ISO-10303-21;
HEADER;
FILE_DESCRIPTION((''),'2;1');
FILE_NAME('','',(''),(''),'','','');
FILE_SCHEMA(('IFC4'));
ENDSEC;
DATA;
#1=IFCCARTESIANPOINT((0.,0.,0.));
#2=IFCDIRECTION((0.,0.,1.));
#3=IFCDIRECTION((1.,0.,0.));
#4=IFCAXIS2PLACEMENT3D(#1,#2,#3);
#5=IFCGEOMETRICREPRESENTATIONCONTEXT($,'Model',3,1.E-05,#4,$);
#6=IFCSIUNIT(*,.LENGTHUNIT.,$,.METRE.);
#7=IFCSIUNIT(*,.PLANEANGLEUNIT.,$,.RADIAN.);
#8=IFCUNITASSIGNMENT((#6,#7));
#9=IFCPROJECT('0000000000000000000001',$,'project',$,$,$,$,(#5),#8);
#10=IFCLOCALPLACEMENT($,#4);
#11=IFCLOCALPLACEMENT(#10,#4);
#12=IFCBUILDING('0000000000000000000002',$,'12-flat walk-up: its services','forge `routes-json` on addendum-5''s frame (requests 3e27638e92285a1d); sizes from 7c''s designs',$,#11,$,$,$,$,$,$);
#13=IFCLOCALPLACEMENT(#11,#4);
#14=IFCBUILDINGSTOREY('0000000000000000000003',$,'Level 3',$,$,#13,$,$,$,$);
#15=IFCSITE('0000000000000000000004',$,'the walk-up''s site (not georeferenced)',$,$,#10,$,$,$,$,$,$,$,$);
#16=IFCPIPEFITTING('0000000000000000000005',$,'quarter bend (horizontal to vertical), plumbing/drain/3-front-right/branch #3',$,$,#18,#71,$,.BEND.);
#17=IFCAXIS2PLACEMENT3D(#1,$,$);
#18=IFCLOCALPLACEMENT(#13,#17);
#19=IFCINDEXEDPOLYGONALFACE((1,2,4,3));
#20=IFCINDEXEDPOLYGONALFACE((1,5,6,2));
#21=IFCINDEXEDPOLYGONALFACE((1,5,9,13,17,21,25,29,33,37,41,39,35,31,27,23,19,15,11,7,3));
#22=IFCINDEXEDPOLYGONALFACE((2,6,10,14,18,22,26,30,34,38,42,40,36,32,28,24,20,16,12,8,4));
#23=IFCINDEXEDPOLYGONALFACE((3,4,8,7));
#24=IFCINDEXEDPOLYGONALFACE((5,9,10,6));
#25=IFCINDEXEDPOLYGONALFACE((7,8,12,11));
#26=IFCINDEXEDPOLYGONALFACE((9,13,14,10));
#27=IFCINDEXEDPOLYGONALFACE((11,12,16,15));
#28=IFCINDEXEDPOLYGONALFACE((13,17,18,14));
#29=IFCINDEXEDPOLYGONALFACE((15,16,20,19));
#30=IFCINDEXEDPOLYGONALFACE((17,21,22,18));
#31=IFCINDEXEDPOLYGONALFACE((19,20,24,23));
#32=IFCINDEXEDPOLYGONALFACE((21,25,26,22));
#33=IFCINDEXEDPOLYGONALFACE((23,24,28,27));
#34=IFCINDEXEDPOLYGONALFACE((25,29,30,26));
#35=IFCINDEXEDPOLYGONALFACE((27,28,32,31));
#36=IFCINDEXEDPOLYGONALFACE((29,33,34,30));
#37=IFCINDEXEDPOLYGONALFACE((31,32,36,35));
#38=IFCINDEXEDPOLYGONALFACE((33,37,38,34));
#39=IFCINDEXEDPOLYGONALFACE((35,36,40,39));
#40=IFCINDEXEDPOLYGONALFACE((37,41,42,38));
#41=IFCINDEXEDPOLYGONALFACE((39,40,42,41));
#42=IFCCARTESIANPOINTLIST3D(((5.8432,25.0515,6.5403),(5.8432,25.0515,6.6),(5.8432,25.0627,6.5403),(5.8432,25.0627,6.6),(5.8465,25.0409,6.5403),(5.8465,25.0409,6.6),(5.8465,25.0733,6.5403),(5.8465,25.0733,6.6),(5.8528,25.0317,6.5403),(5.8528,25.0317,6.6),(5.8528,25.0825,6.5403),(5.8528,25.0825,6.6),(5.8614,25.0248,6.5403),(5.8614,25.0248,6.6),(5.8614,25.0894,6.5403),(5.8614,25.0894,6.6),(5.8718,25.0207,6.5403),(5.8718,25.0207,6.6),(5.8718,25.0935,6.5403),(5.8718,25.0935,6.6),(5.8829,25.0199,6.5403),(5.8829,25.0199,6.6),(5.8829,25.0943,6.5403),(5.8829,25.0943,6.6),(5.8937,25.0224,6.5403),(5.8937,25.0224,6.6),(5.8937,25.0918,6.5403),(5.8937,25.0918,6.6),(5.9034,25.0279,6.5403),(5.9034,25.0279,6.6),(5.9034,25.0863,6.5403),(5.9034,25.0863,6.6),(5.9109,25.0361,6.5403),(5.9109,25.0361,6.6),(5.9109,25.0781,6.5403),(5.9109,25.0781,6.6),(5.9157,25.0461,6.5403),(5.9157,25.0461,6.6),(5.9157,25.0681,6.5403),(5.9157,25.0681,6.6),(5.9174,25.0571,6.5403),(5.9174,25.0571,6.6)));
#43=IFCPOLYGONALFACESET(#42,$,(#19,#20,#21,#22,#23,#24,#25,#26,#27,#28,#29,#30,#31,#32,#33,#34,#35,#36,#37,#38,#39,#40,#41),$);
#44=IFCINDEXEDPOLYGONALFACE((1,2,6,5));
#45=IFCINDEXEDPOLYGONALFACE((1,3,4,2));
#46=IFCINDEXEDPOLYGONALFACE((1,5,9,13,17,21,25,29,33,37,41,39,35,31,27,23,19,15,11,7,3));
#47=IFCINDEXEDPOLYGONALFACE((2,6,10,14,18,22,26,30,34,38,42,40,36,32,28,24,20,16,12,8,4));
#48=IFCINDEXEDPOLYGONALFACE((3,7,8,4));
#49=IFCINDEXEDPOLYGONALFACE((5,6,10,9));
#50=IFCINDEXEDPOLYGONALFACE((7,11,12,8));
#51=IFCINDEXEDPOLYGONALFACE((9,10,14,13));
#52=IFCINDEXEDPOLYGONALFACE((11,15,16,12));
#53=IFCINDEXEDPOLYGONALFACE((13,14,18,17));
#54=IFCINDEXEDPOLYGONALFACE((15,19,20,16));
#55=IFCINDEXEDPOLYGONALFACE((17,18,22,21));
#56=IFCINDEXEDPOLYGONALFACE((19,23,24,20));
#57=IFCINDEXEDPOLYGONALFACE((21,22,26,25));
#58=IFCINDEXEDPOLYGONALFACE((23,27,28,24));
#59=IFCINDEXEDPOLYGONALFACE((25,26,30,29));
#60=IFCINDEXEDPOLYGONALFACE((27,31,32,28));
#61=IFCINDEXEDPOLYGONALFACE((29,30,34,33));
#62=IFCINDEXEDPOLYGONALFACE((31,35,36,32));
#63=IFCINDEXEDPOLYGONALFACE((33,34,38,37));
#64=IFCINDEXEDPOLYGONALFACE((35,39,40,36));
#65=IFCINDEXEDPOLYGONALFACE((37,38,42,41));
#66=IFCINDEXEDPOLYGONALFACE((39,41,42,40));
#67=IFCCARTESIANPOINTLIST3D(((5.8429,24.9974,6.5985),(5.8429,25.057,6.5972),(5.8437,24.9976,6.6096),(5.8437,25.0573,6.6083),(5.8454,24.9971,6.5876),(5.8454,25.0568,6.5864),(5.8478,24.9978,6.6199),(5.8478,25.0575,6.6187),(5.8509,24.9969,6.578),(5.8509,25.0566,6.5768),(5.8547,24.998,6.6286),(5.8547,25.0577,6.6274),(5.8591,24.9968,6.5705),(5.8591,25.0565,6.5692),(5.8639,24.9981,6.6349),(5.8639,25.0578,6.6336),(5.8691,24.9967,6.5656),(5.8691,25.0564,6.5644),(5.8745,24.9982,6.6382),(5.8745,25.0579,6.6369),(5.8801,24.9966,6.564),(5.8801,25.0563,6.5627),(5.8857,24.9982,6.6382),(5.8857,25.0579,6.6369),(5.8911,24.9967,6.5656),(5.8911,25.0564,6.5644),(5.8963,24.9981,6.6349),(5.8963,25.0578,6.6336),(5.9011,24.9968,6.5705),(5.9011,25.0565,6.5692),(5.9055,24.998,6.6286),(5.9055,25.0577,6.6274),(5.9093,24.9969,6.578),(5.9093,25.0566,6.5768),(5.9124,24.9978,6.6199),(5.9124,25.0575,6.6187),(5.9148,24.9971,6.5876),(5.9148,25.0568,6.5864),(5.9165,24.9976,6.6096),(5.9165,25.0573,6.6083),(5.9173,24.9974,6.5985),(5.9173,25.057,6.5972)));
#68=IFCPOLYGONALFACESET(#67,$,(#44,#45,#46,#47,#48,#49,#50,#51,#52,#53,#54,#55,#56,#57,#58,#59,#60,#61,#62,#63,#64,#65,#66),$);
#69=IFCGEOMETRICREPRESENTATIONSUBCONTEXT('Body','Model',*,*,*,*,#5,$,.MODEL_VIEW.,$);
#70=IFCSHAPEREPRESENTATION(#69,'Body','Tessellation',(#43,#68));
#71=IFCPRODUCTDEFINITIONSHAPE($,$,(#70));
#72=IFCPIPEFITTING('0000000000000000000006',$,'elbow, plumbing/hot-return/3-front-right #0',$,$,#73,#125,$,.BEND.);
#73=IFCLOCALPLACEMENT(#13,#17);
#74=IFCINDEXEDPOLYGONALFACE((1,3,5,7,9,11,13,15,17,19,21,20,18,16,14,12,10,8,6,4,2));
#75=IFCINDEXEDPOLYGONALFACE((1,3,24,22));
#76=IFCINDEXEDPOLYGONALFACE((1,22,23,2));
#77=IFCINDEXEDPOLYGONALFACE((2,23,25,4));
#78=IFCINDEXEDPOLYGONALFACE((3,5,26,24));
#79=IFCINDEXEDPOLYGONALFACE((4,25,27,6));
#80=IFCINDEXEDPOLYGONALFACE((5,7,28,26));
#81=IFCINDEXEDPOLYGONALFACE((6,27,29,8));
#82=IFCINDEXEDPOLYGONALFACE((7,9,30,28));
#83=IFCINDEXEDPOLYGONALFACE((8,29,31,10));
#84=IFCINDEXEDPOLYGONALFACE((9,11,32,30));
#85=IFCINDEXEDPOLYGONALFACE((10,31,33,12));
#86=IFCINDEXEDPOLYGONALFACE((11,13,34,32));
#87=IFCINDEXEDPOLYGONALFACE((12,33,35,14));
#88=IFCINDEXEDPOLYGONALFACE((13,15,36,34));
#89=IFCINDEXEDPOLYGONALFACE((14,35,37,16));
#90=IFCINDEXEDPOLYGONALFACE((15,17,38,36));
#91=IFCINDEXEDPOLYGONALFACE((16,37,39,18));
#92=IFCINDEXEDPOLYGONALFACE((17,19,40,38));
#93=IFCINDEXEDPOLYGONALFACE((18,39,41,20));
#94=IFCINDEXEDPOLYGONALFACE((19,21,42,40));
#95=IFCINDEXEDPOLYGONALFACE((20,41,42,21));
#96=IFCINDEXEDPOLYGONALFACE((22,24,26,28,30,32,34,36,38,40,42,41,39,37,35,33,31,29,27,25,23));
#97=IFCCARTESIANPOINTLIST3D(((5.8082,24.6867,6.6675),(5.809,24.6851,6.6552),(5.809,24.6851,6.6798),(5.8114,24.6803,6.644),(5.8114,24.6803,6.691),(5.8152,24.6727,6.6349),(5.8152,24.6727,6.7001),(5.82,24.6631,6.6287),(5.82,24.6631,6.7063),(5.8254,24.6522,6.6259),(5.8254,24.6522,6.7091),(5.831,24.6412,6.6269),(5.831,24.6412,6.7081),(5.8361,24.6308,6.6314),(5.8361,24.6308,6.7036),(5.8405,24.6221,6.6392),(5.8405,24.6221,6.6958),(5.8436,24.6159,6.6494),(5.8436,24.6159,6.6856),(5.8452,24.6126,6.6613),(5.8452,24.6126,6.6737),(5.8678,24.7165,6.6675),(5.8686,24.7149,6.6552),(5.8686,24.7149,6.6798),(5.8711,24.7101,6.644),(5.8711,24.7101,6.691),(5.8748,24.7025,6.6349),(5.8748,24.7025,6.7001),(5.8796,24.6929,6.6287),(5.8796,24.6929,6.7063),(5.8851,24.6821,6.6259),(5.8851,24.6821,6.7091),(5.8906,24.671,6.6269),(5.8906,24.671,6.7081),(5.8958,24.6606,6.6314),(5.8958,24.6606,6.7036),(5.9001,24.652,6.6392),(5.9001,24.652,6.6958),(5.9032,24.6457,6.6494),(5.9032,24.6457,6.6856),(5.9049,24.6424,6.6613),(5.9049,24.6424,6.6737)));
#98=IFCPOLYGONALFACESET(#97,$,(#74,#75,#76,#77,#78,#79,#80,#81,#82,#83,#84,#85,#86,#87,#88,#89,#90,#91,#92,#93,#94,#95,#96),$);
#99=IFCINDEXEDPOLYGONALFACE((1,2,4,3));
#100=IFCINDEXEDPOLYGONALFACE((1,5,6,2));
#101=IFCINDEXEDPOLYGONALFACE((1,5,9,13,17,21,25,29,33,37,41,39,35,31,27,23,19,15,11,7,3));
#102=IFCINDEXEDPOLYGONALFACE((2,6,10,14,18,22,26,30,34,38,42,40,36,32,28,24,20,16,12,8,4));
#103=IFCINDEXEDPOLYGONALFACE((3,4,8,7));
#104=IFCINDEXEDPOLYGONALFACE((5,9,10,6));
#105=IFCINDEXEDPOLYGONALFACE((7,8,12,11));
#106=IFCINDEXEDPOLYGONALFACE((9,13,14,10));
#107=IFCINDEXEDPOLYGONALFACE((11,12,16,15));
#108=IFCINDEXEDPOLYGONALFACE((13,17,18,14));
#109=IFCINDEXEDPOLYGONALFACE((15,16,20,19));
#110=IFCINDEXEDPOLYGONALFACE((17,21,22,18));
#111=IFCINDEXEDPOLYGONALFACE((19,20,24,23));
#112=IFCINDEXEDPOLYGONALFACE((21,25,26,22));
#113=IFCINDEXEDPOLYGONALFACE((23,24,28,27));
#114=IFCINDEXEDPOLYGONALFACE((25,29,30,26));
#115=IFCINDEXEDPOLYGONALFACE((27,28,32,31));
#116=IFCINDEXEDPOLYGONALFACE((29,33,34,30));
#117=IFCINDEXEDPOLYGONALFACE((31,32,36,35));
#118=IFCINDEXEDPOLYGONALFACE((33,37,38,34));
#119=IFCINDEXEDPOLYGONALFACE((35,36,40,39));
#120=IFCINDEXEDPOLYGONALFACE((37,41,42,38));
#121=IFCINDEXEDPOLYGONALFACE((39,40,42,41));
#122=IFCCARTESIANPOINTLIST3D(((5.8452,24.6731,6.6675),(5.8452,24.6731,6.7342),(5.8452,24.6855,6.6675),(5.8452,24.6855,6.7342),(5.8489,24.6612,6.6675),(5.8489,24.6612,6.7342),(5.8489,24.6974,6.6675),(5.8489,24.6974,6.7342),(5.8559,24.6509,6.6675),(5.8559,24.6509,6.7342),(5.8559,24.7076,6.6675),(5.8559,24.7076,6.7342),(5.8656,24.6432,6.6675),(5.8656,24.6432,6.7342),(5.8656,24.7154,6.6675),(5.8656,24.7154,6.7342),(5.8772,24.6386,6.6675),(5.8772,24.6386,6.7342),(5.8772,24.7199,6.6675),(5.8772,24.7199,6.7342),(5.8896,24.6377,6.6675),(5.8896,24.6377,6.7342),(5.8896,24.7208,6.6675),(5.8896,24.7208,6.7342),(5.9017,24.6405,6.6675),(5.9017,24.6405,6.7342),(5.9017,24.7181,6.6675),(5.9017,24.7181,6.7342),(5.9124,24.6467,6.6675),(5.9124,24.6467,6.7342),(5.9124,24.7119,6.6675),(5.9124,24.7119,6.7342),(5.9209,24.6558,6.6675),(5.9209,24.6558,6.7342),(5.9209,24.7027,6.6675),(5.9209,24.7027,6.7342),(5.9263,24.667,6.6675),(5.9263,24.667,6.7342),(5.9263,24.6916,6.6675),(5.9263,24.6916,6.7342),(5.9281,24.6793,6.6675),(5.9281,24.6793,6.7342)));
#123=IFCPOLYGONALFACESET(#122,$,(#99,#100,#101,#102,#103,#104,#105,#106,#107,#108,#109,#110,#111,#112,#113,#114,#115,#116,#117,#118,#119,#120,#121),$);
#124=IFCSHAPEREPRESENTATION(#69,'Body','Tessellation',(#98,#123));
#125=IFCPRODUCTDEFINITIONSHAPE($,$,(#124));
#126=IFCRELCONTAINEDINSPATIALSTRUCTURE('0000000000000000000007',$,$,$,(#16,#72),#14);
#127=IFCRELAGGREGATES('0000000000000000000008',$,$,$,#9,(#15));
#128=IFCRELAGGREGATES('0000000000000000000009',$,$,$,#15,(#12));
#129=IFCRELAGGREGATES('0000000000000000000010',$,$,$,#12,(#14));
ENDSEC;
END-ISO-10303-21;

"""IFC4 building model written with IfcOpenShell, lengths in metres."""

from ifc_helpers import new_model, entity, si_unit, frame, origin_with_axes, place, context, subcontext, project, spatial, element, save


model = new_model("IFC4")

# Units and contexts
model_context = context("Model", 3, precision=1e-05, world=origin_with_axes())
body_context = subcontext(model_context, "Body", "Model", "MODEL_VIEW")
ifc_project = project(units=[si_unit("LENGTHUNIT", "METRE"), si_unit("PLANEANGLEUNIT", "RADIAN")], contexts=[model_context])

# Site, building, storey
site_placement = place(None, origin_with_axes())
site = spatial("IfcSite", under=ifc_project, at=site_placement, Name="the walk-up's site (not georeferenced)")
building_placement = place(site_placement, origin_with_axes())
building = spatial("IfcBuilding", under=site, at=building_placement, Name="12-flat walk-up: its services", Description="forge `routes-json` on addendum-5's frame (requests 3e27638e92285a1d); sizes from 7c's designs")
storey_placement = place(building_placement, origin_with_axes())
storey = spatial("IfcBuildingStorey", under=building, at=storey_placement, Name="Level 3")

# Pipe fittings
pipe_fitting_1_placement = place(storey_placement, frame((5.8801, 25.0571, 6.5403), z_axis=(0.0, 0.0, 1.0), x_axis=(1.0, 0.0, 0.0)))
element("IfcPipeFitting", 1, at=pipe_fitting_1_placement, inside=storey, Name="quarter bend (horizontal to vertical), plumbing/drain/3-front-right/branch #3", PredefinedType="BEND", context=body_context, shape_type="AdvancedSweptSolid", body=[
    entity("IfcSweptDiskSolid", entity("IfcPolyline", [entity("IfcCartesianPoint", [0.0, 0.0, 0.0]), entity("IfcCartesianPoint", [0.0, 0.0, 0.0597])]), 0.0373),
    entity("IfcSweptDiskSolid", entity("IfcPolyline", [entity("IfcCartesianPoint", [0.0, 0.0, 0.0597]), entity("IfcCartesianPoint", [0.0, -0.0597, 0.0609])]), 0.0373),
])
pipe_fitting_2_placement = place(storey_placement, frame((5.8268, 24.6495, 6.6675), z_axis=(0.0, 0.0, 1.0), x_axis=(1.0, 0.0, 0.0)))
element("IfcPipeFitting", 2, at=pipe_fitting_2_placement, inside=storey, Name="elbow, plumbing/hot-return/3-front-right #0", PredefinedType="BEND", context=body_context, shape_type="AdvancedSweptSolid", body=[
    entity("IfcSweptDiskSolid", entity("IfcPolyline", [entity("IfcCartesianPoint", [0.0, 0.0, 0.0]), entity("IfcCartesianPoint", [0.0596, 0.0298, 0.0])]), 0.0417),
    entity("IfcSweptDiskSolid", entity("IfcPolyline", [entity("IfcCartesianPoint", [0.0596, 0.0298, 0.0]), entity("IfcCartesianPoint", [0.0596, 0.0298, 0.0667])]), 0.0417),
])

save(model, "model.ifc")
